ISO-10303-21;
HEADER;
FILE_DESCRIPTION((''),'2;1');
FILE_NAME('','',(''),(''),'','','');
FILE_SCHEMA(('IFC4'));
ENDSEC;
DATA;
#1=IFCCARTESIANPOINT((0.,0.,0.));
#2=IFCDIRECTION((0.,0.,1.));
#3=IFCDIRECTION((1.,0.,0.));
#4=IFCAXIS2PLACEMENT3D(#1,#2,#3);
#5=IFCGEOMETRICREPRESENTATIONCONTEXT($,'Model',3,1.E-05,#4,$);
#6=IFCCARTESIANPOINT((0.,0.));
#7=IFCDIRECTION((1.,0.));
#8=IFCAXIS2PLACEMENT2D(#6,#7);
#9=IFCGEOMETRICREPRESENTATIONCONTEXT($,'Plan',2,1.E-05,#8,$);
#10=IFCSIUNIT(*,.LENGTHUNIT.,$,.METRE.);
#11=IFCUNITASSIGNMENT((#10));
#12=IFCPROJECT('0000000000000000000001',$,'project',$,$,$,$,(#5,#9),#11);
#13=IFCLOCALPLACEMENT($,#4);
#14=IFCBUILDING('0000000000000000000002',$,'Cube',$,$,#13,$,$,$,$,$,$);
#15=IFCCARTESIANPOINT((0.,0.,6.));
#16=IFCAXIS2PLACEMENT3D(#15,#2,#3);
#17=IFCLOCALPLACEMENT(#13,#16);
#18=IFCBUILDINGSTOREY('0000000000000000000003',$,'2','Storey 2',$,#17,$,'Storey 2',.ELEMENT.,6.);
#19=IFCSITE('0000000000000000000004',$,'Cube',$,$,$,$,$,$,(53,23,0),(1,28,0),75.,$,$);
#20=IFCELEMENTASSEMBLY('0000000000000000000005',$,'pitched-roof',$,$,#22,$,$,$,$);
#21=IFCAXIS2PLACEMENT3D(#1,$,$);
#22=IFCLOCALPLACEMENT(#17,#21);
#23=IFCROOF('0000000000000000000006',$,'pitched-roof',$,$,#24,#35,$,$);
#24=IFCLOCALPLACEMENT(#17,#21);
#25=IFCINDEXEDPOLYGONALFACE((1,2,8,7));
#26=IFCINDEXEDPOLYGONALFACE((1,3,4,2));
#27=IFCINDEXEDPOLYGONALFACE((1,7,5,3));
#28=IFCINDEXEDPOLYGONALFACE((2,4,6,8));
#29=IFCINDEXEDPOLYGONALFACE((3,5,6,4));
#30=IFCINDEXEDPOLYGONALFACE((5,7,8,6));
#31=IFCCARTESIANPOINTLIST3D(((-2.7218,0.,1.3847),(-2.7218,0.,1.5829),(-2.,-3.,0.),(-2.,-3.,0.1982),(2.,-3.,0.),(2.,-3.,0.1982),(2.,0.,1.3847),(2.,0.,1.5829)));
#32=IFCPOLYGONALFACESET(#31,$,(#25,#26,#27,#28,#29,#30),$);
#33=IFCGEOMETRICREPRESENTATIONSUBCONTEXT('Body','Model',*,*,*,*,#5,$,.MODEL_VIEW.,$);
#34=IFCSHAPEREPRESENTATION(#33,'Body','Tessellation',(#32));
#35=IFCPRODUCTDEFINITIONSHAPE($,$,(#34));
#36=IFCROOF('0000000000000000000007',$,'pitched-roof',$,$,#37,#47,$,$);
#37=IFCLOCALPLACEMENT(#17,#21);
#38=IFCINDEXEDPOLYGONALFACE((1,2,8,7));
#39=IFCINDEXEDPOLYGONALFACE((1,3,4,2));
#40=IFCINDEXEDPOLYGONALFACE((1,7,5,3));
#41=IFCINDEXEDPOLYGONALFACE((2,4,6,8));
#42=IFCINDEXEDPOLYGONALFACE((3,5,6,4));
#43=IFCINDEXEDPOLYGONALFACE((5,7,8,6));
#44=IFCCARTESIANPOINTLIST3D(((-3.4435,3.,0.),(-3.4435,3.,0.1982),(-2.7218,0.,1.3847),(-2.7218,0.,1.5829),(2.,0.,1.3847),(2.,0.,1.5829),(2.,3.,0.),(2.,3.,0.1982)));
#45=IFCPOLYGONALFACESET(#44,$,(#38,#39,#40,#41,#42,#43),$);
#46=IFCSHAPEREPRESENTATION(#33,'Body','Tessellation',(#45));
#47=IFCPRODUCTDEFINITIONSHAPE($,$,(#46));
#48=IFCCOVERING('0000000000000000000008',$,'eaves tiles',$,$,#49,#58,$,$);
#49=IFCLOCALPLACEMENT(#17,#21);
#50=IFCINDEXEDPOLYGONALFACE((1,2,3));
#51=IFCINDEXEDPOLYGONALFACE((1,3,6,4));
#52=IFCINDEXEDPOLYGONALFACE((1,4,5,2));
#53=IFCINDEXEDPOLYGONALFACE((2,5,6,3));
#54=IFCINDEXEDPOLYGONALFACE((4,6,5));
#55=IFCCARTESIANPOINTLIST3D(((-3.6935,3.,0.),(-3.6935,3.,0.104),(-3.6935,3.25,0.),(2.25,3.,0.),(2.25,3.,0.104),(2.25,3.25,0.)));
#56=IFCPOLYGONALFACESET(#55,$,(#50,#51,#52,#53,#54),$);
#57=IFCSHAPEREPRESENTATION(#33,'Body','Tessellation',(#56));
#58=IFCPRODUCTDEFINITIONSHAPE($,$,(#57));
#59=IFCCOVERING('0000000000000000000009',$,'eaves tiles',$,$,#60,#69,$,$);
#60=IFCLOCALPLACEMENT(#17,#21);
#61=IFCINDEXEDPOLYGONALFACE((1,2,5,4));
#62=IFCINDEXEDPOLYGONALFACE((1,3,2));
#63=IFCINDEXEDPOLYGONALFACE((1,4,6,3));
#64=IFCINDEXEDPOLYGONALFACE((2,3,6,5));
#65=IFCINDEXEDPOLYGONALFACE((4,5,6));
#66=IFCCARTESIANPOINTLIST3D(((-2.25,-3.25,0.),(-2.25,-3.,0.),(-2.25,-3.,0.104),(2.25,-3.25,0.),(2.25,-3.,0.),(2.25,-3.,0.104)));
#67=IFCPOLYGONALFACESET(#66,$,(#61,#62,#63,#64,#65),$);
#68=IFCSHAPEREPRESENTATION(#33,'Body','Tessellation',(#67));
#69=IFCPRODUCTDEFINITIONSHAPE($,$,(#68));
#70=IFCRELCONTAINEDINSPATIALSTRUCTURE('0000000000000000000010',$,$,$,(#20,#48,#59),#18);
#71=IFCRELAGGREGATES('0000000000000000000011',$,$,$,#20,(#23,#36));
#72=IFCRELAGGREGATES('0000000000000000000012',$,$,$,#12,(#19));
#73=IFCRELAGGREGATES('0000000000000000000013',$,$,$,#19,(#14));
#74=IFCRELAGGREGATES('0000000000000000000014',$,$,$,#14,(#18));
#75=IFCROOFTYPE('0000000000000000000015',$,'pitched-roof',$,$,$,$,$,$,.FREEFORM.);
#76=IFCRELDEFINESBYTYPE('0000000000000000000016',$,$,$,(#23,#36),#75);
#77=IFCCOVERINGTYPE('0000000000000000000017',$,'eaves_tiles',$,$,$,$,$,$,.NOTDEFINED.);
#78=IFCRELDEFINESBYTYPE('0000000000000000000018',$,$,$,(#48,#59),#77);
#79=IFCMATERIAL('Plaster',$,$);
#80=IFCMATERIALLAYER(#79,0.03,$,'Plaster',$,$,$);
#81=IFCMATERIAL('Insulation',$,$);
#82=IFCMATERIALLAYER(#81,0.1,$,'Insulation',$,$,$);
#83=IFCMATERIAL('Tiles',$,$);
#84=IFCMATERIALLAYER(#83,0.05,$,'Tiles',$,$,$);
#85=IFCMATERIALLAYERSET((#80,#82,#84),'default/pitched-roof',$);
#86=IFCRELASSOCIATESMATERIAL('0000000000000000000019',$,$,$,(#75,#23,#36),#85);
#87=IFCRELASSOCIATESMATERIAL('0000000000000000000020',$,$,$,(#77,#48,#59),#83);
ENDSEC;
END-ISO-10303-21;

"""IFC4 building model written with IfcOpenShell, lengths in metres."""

from ifc_helpers import new_model, si_unit, frame, origin, origin_with_axes, origin_2d_with_axis, place, context, subcontext, project, spatial, polyline, outline, extrude, material, layer, layer_set, layer_usage, material_profile, profile_set, profile_usage, type_object, element, aggregate, save


model = new_model("IFC4")

# Units and contexts
model_context = context("Model", 3, precision=1e-05, world=origin_with_axes())
plan_context = context("Plan", 2, precision=1e-05, world=origin_2d_with_axis())
body_context = subcontext(model_context, "Body", "Model", "MODEL_VIEW")
ifc_project = project(units=[si_unit("LENGTHUNIT", "METRE")], contexts=[model_context, plan_context])

# Site, building, storey
site = spatial("IfcSite", under=ifc_project, Name="Cube", RefLatitude=(53, 23, 0), RefLongitude=(1, 28, 0), RefElevation=75.0)
building_placement = place(None, origin_with_axes())
building = spatial("IfcBuilding", under=site, at=building_placement, Name="Cube")
storey_placement = place(building_placement, frame((0.0, 0.0, 6.0), z_axis=(0.0, 0.0, 1.0), x_axis=(1.0, 0.0, 0.0)))
storey = spatial("IfcBuildingStorey", under=building, at=storey_placement, Name="2", Description="Storey 2", LongName="Storey 2", CompositionType="ELEMENT", Elevation=6.0)

# Element assembly, roofs
assembly_placement = place(storey_placement, origin_with_axes())
assembly = element("IfcElementAssembly", 1, at=assembly_placement, inside=storey, Name="pitched-roof")
ifc_material_1 = material(Name="Plaster")
ifc_layer_1 = layer(ifc_material_1, 0.03, Name="Plaster")
ifc_material_2 = material(Name="Insulation")
ifc_layer_2 = layer(ifc_material_2, 0.1, Name="Insulation")
ifc_material_3 = material(Name="Tiles")
ifc_layer_3 = layer(ifc_material_3, 0.05, Name="Tiles")
ifc_layer_set = layer_set([ifc_layer_1, ifc_layer_2, ifc_layer_3], Name="default/pitched-roof")
ifc_layer_usage_1 = layer_usage(ifc_layer_set, "AXIS3", "POSITIVE", 0.0)
roof_type = type_object("IfcRoofType", Name="pitched-roof", PredefinedType="FREEFORM", material=ifc_layer_set)
roof_1_placement = place(assembly_placement, frame((-2.0, -3.0, 0.0), z_axis=(0.0, -0.419069, 0.907954), x_axis=(1.0, 0.0, 0.0)))
roof_1 = element("IfcRoof", 2, at=roof_1_placement, type_object=roof_type, material=ifc_layer_usage_1, Name="pitched-roof", context=body_context, shape_type="SweptSolid", body=[
    extrude(outline(polyline([(0.0, 0.0), (4.0, 0.0), (4.0, 3.3041), (-0.7218, 3.3041), (0.0, 0.0)])), origin(), (0.0, 0.419069, 0.907954), 0.1982),
])
ifc_layer_usage_2 = layer_usage(ifc_layer_set, "AXIS3", "POSITIVE", 0.0)
roof_2_placement = place(assembly_placement, frame((-3.4435, 3.0, 0.0), z_axis=(0.0, 0.419069, 0.907954), x_axis=(-1.0, 0.0, 0.0)))
roof_2 = element("IfcRoof", 3, at=roof_2_placement, type_object=roof_type, material=ifc_layer_usage_2, Name="pitched-roof", context=body_context, shape_type="SweptSolid", body=[
    extrude(outline(polyline([(0.0, 0.0), (-0.7218, 3.3041), (-5.4435, 3.3041), (-5.4435, 0.0), (0.0, 0.0)])), origin(), (0.0, 0.419069, 0.907954), 0.1982),
])
aggregate(assembly, [roof_1, roof_2])

# Coverings
ifc_material_profile_1 = material_profile(ifc_material_3, outline(polyline([(0.25, 0.0), (0.0, 0.0), (0.0, 0.104), (0.25, 0.0)])))
ifc_profile_set_1 = profile_set([ifc_material_profile_1])
ifc_profile_usage_1 = profile_usage(ifc_profile_set_1)
covering_type_1 = type_object("IfcCoveringType", Name="eaves_tiles", PredefinedType="NOTDEFINED", material=ifc_profile_set_1)
covering_1_placement = place(storey_placement, frame((-3.6935, 3.0, 0.0), z_axis=(1.0, 0.0, 0.0), x_axis=(0.0, 1.0, 0.0)))
element("IfcCovering", 4, at=covering_1_placement, inside=storey, type_object=covering_type_1, material=ifc_profile_usage_1, Name="eaves tiles", context=body_context, shape_type="SweptSolid", body=[
    extrude(outline(polyline([(0.25, 0.0), (0.0, 0.0), (0.0, 0.104), (0.25, 0.0)])), origin_with_axes(), (0.0, 0.0, 1.0), 5.9435),
])
ifc_profile_usage_2 = profile_usage(ifc_profile_set_1)
covering_2_placement = place(storey_placement, frame((2.25, -3.0, 0.0), z_axis=(-1.0, 0.0, 0.0), x_axis=(0.0, -1.0, 0.0)))
element("IfcCovering", 5, at=covering_2_placement, inside=storey, type_object=covering_type_1, material=ifc_profile_usage_2, Name="eaves tiles", context=body_context, shape_type="SweptSolid", body=[
    extrude(outline(polyline([(0.25, 0.0), (0.0, 0.0), (0.0, 0.104), (0.25, 0.0)])), origin_with_axes(), (0.0, 0.0, 1.0), 4.5),
])

save(model, "model.ifc")
